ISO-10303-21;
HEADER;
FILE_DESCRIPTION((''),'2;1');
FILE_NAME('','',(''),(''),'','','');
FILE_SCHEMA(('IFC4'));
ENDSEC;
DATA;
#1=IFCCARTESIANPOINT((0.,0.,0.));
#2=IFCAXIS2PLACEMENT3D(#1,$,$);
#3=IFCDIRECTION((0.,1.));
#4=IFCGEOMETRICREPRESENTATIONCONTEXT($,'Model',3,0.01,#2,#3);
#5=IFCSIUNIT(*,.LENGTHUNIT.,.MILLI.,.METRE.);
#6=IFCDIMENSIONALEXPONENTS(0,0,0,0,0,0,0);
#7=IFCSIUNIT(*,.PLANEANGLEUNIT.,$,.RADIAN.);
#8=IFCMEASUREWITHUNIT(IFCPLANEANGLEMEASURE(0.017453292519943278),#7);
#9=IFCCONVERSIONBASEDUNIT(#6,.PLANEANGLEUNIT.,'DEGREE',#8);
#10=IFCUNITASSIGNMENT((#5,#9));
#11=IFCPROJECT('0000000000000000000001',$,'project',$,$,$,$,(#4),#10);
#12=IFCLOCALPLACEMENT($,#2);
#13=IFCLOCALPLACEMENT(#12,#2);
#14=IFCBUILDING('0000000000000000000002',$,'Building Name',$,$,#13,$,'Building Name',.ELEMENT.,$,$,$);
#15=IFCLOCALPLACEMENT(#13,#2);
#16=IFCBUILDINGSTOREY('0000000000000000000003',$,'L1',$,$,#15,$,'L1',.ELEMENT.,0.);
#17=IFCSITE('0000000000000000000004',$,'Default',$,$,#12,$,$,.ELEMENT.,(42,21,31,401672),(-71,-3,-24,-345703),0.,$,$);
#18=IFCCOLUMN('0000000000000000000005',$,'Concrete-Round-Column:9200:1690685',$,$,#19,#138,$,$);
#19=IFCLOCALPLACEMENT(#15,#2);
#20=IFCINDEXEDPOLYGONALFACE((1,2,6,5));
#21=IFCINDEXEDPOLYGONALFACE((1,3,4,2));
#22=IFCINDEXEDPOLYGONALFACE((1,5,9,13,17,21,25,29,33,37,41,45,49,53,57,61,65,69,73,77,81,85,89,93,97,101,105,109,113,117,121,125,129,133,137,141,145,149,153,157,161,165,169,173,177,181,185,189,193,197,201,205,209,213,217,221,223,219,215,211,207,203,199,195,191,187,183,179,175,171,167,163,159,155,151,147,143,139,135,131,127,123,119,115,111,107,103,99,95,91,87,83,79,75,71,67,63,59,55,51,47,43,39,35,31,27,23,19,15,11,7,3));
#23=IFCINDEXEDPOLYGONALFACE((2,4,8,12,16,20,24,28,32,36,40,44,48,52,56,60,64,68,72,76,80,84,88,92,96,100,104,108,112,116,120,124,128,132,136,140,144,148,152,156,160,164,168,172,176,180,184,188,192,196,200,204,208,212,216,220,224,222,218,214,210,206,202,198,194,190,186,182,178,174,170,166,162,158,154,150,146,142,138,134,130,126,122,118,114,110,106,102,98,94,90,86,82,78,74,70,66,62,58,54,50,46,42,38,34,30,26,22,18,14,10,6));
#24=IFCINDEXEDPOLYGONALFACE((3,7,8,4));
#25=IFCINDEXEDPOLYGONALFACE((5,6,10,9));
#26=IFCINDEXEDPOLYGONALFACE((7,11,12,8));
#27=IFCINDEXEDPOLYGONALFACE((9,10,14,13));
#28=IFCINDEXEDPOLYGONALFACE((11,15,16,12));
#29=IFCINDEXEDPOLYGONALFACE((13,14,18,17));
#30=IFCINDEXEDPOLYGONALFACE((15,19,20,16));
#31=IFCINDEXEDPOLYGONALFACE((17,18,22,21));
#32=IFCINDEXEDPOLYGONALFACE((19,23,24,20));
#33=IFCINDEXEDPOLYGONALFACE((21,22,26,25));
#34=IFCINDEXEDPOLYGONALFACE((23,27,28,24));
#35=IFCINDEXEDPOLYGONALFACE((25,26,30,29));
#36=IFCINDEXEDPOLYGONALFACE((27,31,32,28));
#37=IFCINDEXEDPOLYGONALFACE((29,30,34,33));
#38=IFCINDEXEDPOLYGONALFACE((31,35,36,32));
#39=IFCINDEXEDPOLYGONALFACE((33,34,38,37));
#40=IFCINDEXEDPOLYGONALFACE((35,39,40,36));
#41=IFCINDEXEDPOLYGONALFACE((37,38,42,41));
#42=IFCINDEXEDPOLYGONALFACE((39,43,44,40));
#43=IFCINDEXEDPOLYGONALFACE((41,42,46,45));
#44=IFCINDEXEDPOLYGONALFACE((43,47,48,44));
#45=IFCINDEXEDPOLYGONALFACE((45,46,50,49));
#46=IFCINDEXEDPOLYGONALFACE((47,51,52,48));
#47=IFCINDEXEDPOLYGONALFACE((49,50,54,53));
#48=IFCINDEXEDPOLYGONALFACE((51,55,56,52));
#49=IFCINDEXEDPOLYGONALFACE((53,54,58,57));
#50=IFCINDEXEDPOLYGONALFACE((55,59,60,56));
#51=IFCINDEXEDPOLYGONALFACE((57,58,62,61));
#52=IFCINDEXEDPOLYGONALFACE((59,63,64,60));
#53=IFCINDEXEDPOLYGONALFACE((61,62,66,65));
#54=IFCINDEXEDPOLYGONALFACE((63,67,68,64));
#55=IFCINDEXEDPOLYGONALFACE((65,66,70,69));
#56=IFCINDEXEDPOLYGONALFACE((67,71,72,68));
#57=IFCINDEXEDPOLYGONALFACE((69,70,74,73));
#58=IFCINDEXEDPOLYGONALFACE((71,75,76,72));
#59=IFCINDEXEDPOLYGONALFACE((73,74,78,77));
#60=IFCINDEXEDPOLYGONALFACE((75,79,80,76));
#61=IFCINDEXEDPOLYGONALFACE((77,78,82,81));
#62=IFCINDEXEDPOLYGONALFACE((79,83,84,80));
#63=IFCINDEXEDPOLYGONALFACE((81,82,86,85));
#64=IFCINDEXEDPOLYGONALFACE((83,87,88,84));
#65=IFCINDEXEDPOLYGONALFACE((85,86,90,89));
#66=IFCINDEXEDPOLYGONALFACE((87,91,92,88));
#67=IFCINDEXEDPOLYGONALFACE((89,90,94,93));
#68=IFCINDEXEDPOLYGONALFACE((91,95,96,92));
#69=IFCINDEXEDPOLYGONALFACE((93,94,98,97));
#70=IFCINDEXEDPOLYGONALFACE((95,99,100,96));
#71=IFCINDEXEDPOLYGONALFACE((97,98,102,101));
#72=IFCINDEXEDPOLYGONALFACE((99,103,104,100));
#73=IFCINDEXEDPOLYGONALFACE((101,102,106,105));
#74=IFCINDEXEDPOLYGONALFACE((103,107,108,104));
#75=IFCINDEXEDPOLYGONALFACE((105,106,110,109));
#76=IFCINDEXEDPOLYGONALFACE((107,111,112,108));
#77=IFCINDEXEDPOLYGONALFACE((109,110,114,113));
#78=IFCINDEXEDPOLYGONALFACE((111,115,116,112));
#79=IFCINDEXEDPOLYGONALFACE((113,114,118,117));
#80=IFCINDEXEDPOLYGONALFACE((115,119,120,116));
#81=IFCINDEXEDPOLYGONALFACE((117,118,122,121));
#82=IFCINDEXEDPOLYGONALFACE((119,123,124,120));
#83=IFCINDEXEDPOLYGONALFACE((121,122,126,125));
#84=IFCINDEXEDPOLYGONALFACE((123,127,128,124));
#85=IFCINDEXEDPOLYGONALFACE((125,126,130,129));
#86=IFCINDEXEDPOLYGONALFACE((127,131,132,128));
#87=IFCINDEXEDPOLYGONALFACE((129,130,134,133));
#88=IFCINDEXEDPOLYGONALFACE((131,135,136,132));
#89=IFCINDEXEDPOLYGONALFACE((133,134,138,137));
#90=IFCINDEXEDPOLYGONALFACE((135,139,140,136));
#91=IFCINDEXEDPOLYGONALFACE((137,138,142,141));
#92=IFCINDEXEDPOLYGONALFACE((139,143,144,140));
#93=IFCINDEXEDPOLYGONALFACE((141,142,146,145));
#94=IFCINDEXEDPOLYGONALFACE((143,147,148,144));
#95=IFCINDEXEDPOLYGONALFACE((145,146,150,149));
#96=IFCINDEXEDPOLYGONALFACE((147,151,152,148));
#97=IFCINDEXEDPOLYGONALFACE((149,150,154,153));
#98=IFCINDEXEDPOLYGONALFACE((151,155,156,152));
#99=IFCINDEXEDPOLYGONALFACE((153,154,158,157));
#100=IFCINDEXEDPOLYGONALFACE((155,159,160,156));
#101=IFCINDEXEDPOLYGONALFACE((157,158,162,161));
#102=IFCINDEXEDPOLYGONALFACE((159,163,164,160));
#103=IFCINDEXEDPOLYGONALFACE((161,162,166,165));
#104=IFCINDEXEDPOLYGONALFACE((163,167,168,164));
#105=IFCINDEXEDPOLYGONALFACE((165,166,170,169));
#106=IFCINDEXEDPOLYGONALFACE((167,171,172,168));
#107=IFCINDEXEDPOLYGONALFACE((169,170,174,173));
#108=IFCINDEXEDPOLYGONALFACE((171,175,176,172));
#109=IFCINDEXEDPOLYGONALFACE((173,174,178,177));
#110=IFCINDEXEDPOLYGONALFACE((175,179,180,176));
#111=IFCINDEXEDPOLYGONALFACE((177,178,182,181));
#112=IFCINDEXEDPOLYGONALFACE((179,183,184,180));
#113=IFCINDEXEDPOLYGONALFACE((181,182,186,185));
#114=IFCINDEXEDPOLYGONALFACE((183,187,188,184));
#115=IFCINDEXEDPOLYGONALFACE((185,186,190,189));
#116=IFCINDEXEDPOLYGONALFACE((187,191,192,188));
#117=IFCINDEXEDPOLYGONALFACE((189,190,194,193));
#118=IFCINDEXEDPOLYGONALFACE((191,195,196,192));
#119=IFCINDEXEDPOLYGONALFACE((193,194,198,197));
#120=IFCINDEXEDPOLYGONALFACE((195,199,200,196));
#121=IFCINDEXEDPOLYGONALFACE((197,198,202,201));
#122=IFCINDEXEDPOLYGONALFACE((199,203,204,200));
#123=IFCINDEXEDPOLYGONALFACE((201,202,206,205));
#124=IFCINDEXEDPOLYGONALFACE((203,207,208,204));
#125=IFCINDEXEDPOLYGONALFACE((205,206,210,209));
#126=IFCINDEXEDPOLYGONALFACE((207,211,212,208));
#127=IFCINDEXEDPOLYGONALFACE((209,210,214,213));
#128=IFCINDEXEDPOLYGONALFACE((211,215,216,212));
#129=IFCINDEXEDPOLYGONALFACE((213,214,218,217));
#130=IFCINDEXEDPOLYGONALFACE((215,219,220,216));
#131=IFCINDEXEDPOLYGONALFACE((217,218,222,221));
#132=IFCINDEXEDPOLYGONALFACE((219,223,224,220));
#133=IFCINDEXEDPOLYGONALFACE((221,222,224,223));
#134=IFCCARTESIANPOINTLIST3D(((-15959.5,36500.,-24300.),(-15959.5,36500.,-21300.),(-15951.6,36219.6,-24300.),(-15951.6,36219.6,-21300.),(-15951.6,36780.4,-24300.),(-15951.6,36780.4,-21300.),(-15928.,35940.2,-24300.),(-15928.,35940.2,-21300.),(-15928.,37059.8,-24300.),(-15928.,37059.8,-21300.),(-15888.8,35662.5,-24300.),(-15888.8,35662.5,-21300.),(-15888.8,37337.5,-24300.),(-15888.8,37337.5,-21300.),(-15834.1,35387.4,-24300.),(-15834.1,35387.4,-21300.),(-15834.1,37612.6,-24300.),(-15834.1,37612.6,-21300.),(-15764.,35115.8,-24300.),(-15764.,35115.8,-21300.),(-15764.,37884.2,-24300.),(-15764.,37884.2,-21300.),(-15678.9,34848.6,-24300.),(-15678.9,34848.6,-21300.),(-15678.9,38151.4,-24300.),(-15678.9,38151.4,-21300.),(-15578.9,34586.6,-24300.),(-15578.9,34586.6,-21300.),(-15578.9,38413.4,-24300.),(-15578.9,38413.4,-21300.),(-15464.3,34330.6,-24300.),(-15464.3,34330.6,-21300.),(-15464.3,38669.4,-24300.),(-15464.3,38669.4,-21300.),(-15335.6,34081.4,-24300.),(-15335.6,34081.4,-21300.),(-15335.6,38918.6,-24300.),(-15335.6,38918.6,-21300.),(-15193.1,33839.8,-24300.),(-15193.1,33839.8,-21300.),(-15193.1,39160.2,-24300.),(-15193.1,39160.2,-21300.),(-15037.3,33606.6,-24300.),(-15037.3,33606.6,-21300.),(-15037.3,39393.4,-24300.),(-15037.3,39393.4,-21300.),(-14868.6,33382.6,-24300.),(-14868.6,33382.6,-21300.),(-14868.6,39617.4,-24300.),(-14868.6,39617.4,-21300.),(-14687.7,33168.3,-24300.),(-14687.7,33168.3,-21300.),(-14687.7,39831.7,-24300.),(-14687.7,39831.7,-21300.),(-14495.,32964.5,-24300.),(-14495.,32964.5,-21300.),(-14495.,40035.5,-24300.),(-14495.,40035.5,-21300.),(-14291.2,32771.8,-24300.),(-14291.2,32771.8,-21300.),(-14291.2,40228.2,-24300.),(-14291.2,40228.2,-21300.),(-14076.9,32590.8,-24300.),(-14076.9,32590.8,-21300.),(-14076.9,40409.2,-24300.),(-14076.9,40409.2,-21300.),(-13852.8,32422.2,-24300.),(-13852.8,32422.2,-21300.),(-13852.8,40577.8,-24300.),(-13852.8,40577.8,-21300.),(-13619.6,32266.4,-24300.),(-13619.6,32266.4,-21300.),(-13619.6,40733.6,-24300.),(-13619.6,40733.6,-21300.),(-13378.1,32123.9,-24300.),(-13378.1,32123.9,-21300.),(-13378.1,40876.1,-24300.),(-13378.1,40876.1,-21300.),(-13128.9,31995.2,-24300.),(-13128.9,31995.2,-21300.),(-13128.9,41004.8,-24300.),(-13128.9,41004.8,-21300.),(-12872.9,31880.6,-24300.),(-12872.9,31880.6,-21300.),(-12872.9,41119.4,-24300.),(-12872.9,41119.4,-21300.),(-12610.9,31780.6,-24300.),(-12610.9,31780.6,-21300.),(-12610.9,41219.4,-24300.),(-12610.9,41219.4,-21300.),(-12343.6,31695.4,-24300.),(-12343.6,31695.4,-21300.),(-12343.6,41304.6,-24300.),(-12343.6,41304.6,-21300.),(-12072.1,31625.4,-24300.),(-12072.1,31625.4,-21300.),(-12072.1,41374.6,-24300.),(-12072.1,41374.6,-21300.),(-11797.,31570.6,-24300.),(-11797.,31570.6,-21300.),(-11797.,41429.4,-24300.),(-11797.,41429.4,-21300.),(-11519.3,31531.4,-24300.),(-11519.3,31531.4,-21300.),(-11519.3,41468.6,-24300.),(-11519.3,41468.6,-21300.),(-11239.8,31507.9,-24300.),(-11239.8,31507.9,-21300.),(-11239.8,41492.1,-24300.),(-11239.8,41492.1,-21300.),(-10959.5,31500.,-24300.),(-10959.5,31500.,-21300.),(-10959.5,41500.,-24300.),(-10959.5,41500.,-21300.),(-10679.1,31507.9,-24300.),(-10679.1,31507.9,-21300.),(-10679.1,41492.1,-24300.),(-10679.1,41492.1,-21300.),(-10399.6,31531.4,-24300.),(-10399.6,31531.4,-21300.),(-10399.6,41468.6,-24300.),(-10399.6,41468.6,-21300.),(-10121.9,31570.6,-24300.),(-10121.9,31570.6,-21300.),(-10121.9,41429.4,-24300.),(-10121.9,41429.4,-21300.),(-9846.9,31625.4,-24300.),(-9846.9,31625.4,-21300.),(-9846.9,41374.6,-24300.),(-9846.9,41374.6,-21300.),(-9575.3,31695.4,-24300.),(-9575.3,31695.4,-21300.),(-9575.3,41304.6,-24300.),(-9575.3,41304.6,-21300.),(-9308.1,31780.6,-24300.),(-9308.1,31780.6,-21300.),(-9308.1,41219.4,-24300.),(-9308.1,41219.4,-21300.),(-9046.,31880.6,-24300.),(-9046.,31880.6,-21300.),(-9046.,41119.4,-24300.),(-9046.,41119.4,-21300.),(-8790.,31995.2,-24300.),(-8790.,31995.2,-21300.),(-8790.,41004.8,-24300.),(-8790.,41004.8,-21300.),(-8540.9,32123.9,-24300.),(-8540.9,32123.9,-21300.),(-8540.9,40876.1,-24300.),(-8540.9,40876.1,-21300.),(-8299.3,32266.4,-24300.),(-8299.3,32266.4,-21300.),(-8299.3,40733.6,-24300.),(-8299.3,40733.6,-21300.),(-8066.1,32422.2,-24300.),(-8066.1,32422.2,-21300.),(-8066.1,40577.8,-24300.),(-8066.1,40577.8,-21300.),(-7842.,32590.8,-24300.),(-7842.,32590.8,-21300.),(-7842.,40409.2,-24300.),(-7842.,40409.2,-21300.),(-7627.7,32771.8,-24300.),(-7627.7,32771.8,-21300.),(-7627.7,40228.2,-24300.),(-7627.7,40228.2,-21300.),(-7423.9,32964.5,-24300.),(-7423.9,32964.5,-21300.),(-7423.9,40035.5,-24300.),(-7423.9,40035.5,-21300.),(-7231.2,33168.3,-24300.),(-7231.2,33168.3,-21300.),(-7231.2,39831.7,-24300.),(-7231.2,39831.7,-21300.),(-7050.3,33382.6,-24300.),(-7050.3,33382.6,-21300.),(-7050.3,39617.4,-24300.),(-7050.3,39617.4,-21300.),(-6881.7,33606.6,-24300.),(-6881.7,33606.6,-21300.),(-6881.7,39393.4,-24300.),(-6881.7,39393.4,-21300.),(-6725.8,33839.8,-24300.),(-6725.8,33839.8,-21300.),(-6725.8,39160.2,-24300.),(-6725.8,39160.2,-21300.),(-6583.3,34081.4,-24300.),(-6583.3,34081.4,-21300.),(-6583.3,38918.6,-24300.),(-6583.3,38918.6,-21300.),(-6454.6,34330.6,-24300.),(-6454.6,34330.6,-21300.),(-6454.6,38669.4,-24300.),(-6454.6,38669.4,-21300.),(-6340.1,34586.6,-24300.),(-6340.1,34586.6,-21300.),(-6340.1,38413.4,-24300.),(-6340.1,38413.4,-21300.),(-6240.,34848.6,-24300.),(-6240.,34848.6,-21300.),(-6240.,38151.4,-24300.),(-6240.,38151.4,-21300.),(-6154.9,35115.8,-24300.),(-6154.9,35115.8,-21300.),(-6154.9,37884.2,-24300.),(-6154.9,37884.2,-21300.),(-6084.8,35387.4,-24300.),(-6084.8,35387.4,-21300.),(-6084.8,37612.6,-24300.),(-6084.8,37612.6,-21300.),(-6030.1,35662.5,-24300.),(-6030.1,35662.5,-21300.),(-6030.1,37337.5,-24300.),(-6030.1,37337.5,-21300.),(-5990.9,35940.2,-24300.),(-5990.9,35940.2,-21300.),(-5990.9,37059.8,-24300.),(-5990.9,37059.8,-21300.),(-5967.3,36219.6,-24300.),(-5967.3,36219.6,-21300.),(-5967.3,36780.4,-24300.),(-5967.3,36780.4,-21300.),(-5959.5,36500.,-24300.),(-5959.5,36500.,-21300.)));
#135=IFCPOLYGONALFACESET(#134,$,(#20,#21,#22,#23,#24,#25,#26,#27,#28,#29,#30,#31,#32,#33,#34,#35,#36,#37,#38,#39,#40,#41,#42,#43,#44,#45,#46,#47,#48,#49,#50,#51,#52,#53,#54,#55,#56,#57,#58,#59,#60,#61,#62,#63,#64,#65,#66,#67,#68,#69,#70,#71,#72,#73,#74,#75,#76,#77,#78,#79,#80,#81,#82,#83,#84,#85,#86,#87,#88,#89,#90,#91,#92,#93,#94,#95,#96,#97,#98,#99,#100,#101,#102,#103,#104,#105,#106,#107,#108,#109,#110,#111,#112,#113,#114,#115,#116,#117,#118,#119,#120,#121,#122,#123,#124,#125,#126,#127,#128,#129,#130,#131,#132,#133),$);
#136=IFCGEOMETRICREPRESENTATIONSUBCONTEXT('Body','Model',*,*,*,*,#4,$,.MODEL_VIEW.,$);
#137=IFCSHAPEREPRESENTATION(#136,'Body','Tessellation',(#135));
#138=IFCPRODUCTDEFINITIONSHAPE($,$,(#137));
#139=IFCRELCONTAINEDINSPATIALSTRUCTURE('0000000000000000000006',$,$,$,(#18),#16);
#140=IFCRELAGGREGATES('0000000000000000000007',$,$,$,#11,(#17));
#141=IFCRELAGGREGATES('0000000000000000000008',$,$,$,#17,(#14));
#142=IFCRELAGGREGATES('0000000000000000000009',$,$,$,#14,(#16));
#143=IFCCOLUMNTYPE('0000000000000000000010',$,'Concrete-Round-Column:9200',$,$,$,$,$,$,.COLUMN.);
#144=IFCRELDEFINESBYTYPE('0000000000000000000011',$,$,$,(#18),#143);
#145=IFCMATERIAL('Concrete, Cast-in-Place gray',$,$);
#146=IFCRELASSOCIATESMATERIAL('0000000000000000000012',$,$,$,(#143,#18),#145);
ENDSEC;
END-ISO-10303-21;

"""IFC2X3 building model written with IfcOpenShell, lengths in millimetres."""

from ifc_helpers import new_model, entity, si_unit, converted_unit, direction, frame, frame_2d, origin, place, context, subcontext, project, spatial, circle, extrude, source, transform, mapped, material, type_object, type_shapes, element, save


model = new_model("IFC2X3")

# Units and contexts
model_context = context("Model", 3, precision=0.01, world=origin(), true_north=direction((0.0, 1.0)))
body_context = subcontext(model_context, "Body", "Model", "MODEL_VIEW")
ifc_project = project(units=[si_unit("LENGTHUNIT", "METRE", prefix="MILLI"), converted_unit("PLANEANGLEUNIT", "DEGREE", entity("IfcPlaneAngleMeasure", 0.017453292519943278), si_unit("PLANEANGLEUNIT", "RADIAN"), dimensions=[0, 0, 0, 0, 0, 0, 0])], contexts=[model_context])

# Site, building, storey
site_placement = place(None, origin())
site = spatial("IfcSite", under=ifc_project, at=site_placement, Name="Default", CompositionType="ELEMENT", RefLatitude=(42, 21, 31, 401672), RefLongitude=(-71, -3, -24, -345703), RefElevation=0.0)
building_placement = place(site_placement, origin())
building = spatial("IfcBuilding", under=site, at=building_placement, Name="Building Name", LongName="Building Name", CompositionType="ELEMENT")
storey_placement = place(building_placement, origin())
storey = spatial("IfcBuildingStorey", under=building, at=storey_placement, Name="L1", LongName="L1", CompositionType="ELEMENT", Elevation=0.0)

# Column
ifc_material_1 = material(Name="Concrete, Cast-in-Place gray")
column_type_1 = type_object("IfcColumnType", Name="Concrete-Round-Column:9200", PredefinedType="COLUMN", material=ifc_material_1)
shared_shape_1 = source(origin(), body_context, "Body", "SweptSolid", [
    extrude(circle(Radius=5000.0, at=frame_2d((0.0, 0.0), x_axis=(1.0, 0.0))), frame((0.0, 0.0, -24300.0)), (0.0, 0.0, 1.0), 3000.0),
])
type_shapes(column_type_1, [shared_shape_1])
for number, where, name in (
    (1, (-10959.5, 36500.0, 0.0), "Concrete-Round-Column:9200:1690685"),
):
    element("IfcColumn", number, at=place(storey_placement, frame(where)), inside=storey, type_object=column_type_1, material=ifc_material_1, Name=name, context=body_context, shape_type="MappedRepresentation", body=[
        mapped(shared_shape_1, transform((0.0, 0.0, 0.0), scale=1.0)),
    ])

save(model, "model.ifc")
